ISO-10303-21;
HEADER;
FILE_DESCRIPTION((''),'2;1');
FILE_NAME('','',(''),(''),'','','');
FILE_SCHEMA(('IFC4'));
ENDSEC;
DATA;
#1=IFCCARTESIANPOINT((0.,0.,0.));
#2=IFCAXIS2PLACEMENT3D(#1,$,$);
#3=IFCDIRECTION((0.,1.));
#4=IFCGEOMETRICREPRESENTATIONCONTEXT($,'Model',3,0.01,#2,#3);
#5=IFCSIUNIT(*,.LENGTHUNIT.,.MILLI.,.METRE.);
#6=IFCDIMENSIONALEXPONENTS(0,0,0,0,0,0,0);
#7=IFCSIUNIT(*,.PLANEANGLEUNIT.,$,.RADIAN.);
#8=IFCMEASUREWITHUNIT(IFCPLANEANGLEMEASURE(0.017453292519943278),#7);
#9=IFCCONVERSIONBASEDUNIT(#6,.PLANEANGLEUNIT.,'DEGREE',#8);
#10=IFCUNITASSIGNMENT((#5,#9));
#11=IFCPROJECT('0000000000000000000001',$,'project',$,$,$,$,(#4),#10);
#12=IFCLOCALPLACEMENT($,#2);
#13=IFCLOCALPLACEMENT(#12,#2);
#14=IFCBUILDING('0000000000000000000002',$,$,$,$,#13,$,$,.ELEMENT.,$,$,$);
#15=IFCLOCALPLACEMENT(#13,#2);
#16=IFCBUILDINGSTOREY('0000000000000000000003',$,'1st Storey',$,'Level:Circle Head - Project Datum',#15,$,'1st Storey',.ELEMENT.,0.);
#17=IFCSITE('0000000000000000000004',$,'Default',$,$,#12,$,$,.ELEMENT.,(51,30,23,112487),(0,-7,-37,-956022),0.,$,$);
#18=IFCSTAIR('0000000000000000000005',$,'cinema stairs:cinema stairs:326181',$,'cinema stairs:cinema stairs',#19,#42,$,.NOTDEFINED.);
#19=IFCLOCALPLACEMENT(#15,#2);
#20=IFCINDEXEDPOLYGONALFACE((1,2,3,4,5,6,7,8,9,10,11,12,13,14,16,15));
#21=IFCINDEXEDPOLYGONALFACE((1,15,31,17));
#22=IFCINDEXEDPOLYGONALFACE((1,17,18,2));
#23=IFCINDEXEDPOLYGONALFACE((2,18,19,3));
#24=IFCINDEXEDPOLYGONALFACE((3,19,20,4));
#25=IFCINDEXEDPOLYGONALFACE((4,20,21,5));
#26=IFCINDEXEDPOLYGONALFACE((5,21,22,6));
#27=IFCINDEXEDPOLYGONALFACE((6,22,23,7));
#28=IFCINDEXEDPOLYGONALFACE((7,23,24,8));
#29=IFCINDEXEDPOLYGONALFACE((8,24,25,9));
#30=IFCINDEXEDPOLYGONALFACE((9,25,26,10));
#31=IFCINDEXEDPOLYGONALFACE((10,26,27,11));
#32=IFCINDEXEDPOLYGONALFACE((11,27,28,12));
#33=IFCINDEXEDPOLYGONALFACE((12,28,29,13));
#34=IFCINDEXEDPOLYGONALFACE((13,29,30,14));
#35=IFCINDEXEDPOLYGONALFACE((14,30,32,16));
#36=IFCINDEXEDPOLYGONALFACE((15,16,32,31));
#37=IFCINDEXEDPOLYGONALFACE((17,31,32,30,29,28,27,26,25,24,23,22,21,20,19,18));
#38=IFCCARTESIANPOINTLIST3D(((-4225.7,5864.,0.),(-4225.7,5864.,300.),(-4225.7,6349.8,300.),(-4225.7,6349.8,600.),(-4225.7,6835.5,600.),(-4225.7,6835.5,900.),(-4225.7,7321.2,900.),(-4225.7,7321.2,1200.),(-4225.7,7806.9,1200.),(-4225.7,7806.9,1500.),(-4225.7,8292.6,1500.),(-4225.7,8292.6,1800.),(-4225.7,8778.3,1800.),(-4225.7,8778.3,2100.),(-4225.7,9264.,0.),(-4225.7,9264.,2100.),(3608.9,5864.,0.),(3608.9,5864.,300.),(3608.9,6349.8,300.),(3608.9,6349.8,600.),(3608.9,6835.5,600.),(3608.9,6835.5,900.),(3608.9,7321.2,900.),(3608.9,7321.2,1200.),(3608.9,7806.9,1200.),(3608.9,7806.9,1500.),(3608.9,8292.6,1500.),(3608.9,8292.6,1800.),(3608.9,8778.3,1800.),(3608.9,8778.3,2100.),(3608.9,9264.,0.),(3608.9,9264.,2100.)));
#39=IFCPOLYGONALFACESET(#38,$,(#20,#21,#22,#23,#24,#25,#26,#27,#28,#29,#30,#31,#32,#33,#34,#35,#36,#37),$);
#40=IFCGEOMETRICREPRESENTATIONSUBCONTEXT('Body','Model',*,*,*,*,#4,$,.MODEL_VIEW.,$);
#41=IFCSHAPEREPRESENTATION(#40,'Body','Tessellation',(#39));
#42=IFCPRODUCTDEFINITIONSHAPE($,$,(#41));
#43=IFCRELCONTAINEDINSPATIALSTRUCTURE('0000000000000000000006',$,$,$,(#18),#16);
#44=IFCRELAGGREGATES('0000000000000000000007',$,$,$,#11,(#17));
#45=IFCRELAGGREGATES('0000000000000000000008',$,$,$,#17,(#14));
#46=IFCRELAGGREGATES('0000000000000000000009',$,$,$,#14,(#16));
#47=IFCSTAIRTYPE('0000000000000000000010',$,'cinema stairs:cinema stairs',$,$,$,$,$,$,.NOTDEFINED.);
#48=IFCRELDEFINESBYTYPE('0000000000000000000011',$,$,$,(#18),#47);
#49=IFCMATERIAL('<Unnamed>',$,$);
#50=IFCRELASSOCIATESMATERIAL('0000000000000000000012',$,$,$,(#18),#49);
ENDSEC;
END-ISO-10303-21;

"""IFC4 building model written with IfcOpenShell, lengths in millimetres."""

from ifc_helpers import new_model, entity, si_unit, converted_unit, direction, frame, origin, place, context, subcontext, project, spatial, indexed_curve, outline, extrude, material, type_object, element, save


model = new_model("IFC4")

# Units and contexts
model_context = context("Model", 3, precision=0.01, world=origin(), true_north=direction((0.0, 1.0)))
body_context = subcontext(model_context, "Body", "Model", "MODEL_VIEW")
ifc_project = project(units=[si_unit("LENGTHUNIT", "METRE", prefix="MILLI"), converted_unit("PLANEANGLEUNIT", "DEGREE", entity("IfcPlaneAngleMeasure", 0.017453292519943278), si_unit("PLANEANGLEUNIT", "RADIAN"), dimensions=[0, 0, 0, 0, 0, 0, 0])], contexts=[model_context])

# Site, building, storey
site_placement = place(None, origin())
site = spatial("IfcSite", under=ifc_project, at=site_placement, Name="Default", CompositionType="ELEMENT", RefLatitude=(51, 30, 23, 112487), RefLongitude=(0, -7, -37, -956022), RefElevation=0.0)
building_placement = place(site_placement, origin())
building = spatial("IfcBuilding", under=site, at=building_placement, CompositionType="ELEMENT")
storey_placement = place(building_placement, origin())
storey = spatial("IfcBuildingStorey", under=building, at=storey_placement, Name="1st Storey", ObjectType="Level:Circle Head - Project Datum", LongName="1st Storey", CompositionType="ELEMENT", Elevation=0.0)

# Shared definitions
ifc_material_1 = material(Name="<Unnamed>")

# Stair
stair_type_1 = type_object("IfcStairType", Name="cinema stairs:cinema stairs", PredefinedType="NOTDEFINED")
stair_1_placement = place(storey_placement, origin())
element("IfcStair", 1, at=stair_1_placement, inside=storey, type_object=stair_type_1, material=ifc_material_1, Name="cinema stairs:cinema stairs:326181", ObjectType="cinema stairs:cinema stairs", PredefinedType="NOTDEFINED", context=body_context, shape_type="SweptSolid", body=[
    extrude(outline(indexed_curve([(-1700.0, -1050.0), (-1214.3, -1050.0), (-1214.3, -750.0), (-728.6, -750.0), (-728.6, -450.0), (-242.9, -450.0), (-242.9, -150.0), (242.9, -150.0), (242.9, 150.0), (728.6, 150.0), (728.6, 450.0), (1214.3, 450.0), (1214.3, 750.0), (1700.0, 750.0), (1700.0, 1050.0), (-1700.0, 1050.0), (-1700.0, -1050.0)], self_intersect=False)), frame((-4225.7, 7564.0, 1050.0), z_axis=(1.0, 0.0, 0.0), x_axis=(0.0, -1.0, 0.0)), (0.0, 0.0, 1.0), 7834.6),
])

save(model, "model.ifc")
